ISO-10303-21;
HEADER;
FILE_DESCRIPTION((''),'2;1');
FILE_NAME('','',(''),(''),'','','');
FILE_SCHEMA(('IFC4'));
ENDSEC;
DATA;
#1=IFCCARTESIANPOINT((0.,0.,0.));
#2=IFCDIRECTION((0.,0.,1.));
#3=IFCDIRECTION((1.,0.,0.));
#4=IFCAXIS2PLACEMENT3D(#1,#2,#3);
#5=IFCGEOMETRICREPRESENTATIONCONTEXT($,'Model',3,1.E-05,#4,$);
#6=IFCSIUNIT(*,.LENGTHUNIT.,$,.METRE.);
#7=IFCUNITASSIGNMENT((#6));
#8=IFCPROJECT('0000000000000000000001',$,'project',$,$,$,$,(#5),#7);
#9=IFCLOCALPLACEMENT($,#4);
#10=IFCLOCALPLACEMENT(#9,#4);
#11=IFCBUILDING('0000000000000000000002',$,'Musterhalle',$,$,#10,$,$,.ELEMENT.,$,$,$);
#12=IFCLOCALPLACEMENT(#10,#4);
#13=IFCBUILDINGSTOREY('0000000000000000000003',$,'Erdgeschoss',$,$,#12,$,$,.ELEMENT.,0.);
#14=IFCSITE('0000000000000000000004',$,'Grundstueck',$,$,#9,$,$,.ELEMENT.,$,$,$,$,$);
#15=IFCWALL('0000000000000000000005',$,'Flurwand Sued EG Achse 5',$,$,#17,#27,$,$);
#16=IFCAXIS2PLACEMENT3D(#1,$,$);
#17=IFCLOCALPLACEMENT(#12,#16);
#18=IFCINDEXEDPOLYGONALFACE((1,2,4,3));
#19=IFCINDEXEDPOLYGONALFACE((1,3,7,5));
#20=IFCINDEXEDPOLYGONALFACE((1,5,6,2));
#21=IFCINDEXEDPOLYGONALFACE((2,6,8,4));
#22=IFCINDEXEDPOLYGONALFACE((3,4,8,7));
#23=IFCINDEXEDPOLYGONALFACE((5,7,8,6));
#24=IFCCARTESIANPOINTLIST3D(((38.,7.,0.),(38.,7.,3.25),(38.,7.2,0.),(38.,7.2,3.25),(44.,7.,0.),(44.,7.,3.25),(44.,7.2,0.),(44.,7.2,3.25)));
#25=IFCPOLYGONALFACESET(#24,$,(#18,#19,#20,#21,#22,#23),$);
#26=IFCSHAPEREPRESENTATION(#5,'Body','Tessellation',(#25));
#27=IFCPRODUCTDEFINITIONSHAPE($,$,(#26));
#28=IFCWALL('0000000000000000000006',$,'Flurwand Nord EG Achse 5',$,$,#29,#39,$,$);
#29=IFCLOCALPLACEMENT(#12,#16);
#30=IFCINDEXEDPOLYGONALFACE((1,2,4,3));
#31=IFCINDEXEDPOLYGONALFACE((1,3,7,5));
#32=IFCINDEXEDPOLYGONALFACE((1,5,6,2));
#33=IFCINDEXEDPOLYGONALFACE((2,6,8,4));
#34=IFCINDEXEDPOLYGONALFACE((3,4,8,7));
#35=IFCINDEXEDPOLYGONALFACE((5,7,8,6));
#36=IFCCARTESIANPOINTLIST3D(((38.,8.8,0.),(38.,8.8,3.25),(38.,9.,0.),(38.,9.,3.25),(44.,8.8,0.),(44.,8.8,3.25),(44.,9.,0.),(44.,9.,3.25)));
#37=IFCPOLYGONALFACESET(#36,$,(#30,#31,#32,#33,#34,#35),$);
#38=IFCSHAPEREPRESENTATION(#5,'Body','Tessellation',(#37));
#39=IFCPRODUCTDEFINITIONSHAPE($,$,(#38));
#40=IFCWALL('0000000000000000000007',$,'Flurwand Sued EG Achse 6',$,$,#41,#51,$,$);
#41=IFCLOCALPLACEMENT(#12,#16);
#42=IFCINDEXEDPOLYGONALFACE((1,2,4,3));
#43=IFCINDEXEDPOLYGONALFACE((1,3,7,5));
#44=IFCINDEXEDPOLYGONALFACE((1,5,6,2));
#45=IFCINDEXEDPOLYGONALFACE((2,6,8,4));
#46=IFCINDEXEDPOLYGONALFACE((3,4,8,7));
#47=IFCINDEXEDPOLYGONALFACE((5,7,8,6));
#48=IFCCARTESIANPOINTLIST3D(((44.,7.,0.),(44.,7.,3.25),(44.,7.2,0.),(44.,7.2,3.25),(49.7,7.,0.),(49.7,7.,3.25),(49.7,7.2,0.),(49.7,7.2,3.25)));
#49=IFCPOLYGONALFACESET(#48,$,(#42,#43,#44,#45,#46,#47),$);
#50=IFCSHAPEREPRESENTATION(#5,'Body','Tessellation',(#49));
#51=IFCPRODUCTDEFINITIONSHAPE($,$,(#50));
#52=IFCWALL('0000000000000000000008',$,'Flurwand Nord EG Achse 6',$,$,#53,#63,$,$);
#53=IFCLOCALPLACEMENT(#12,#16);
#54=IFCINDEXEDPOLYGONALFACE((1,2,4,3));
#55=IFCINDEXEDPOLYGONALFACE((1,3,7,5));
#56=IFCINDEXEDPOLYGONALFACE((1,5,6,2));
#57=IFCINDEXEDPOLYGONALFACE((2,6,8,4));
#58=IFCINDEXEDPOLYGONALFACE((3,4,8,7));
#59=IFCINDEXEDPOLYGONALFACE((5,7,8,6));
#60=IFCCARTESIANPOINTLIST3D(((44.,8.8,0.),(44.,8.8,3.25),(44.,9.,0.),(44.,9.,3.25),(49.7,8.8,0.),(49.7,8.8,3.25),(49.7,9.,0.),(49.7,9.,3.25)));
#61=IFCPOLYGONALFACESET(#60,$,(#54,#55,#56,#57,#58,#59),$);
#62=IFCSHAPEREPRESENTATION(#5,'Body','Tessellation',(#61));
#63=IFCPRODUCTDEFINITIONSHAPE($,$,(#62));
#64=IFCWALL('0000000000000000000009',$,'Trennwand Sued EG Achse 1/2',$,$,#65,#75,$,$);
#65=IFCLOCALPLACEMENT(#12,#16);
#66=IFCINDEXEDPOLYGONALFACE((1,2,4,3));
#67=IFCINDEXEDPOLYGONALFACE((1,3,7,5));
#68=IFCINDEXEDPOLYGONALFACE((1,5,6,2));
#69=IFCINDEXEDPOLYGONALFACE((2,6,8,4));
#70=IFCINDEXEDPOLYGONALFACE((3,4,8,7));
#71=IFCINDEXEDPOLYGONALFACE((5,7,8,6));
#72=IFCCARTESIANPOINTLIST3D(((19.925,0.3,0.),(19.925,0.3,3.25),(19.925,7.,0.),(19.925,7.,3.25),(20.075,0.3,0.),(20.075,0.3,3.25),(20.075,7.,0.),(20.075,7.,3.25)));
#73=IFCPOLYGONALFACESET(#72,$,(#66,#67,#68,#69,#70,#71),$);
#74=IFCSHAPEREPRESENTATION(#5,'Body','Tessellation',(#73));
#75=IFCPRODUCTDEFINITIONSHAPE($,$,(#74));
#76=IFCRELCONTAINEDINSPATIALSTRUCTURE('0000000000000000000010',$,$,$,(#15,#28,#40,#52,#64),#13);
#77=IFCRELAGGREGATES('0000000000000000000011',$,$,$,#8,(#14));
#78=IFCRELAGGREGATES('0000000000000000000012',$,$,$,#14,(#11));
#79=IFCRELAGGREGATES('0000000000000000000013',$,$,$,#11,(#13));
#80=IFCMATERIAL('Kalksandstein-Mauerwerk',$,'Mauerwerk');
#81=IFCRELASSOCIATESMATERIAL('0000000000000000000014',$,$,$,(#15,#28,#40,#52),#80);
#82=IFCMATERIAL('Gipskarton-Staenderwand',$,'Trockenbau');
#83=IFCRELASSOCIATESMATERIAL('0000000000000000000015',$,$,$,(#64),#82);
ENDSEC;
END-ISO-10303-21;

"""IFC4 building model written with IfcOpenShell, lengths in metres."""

from ifc_helpers import new_model, si_unit, frame, origin_with_axes, origin_2d, place, context, project, spatial, rectangle, extrude, material, element, save


model = new_model("IFC4")

# Units and contexts
model_context = context("Model", 3, precision=1e-05, world=origin_with_axes())
ifc_project = project(units=[si_unit("LENGTHUNIT", "METRE")], contexts=[model_context])

# Site, building, storey
site_placement = place(None, origin_with_axes())
site = spatial("IfcSite", under=ifc_project, at=site_placement, Name="Grundstueck", CompositionType="ELEMENT")
building_placement = place(site_placement, origin_with_axes())
building = spatial("IfcBuilding", under=site, at=building_placement, Name="Musterhalle", CompositionType="ELEMENT")
storey_placement = place(building_placement, origin_with_axes())
storey = spatial("IfcBuildingStorey", under=building, at=storey_placement, Name="Erdgeschoss", CompositionType="ELEMENT", Elevation=0.0)

# Walls
ifc_material_1 = material(Name="Kalksandstein-Mauerwerk", Category="Mauerwerk")
placement = place(storey_placement, origin_with_axes())
element("IfcWall", 1, at=placement, inside=storey, material=ifc_material_1, Name="Flurwand Sued EG Achse 5", context=model_context, shape_type="SweptSolid", body=[
    extrude(rectangle(XDim=6.0, YDim=0.2, at=origin_2d()), frame((41.0, 7.1, 0.0), z_axis=(0.0, 0.0, 1.0), x_axis=(1.0, 0.0, 0.0)), (0.0, 0.0, 1.0), 3.25),
])
element("IfcWall", 2, at=placement, inside=storey, material=ifc_material_1, Name="Flurwand Nord EG Achse 5", context=model_context, shape_type="SweptSolid", body=[
    extrude(rectangle(XDim=6.0, YDim=0.2, at=origin_2d()), frame((41.0, 8.9, 0.0), z_axis=(0.0, 0.0, 1.0), x_axis=(1.0, 0.0, 0.0)), (0.0, 0.0, 1.0), 3.25),
])
element("IfcWall", 3, at=placement, inside=storey, material=ifc_material_1, Name="Flurwand Sued EG Achse 6", context=model_context, shape_type="SweptSolid", body=[
    extrude(rectangle(XDim=5.7, YDim=0.2, at=origin_2d()), frame((46.85, 7.1, 0.0), z_axis=(0.0, 0.0, 1.0), x_axis=(1.0, 0.0, 0.0)), (0.0, 0.0, 1.0), 3.25),
])
element("IfcWall", 4, at=placement, inside=storey, material=ifc_material_1, Name="Flurwand Nord EG Achse 6", context=model_context, shape_type="SweptSolid", body=[
    extrude(rectangle(XDim=5.7, YDim=0.2, at=origin_2d()), frame((46.85, 8.9, 0.0), z_axis=(0.0, 0.0, 1.0), x_axis=(1.0, 0.0, 0.0)), (0.0, 0.0, 1.0), 3.25),
])
ifc_material_2 = material(Name="Gipskarton-Staenderwand", Category="Trockenbau")
element("IfcWall", 5, at=placement, inside=storey, material=ifc_material_2, Name="Trennwand Sued EG Achse 1/2", context=model_context, shape_type="SweptSolid", body=[
    extrude(rectangle(XDim=0.15, YDim=6.7, at=origin_2d()), frame((20.0, 3.65, 0.0), z_axis=(0.0, 0.0, 1.0), x_axis=(1.0, 0.0, 0.0)), (0.0, 0.0, 1.0), 3.25),
])

save(model, "model.ifc")
